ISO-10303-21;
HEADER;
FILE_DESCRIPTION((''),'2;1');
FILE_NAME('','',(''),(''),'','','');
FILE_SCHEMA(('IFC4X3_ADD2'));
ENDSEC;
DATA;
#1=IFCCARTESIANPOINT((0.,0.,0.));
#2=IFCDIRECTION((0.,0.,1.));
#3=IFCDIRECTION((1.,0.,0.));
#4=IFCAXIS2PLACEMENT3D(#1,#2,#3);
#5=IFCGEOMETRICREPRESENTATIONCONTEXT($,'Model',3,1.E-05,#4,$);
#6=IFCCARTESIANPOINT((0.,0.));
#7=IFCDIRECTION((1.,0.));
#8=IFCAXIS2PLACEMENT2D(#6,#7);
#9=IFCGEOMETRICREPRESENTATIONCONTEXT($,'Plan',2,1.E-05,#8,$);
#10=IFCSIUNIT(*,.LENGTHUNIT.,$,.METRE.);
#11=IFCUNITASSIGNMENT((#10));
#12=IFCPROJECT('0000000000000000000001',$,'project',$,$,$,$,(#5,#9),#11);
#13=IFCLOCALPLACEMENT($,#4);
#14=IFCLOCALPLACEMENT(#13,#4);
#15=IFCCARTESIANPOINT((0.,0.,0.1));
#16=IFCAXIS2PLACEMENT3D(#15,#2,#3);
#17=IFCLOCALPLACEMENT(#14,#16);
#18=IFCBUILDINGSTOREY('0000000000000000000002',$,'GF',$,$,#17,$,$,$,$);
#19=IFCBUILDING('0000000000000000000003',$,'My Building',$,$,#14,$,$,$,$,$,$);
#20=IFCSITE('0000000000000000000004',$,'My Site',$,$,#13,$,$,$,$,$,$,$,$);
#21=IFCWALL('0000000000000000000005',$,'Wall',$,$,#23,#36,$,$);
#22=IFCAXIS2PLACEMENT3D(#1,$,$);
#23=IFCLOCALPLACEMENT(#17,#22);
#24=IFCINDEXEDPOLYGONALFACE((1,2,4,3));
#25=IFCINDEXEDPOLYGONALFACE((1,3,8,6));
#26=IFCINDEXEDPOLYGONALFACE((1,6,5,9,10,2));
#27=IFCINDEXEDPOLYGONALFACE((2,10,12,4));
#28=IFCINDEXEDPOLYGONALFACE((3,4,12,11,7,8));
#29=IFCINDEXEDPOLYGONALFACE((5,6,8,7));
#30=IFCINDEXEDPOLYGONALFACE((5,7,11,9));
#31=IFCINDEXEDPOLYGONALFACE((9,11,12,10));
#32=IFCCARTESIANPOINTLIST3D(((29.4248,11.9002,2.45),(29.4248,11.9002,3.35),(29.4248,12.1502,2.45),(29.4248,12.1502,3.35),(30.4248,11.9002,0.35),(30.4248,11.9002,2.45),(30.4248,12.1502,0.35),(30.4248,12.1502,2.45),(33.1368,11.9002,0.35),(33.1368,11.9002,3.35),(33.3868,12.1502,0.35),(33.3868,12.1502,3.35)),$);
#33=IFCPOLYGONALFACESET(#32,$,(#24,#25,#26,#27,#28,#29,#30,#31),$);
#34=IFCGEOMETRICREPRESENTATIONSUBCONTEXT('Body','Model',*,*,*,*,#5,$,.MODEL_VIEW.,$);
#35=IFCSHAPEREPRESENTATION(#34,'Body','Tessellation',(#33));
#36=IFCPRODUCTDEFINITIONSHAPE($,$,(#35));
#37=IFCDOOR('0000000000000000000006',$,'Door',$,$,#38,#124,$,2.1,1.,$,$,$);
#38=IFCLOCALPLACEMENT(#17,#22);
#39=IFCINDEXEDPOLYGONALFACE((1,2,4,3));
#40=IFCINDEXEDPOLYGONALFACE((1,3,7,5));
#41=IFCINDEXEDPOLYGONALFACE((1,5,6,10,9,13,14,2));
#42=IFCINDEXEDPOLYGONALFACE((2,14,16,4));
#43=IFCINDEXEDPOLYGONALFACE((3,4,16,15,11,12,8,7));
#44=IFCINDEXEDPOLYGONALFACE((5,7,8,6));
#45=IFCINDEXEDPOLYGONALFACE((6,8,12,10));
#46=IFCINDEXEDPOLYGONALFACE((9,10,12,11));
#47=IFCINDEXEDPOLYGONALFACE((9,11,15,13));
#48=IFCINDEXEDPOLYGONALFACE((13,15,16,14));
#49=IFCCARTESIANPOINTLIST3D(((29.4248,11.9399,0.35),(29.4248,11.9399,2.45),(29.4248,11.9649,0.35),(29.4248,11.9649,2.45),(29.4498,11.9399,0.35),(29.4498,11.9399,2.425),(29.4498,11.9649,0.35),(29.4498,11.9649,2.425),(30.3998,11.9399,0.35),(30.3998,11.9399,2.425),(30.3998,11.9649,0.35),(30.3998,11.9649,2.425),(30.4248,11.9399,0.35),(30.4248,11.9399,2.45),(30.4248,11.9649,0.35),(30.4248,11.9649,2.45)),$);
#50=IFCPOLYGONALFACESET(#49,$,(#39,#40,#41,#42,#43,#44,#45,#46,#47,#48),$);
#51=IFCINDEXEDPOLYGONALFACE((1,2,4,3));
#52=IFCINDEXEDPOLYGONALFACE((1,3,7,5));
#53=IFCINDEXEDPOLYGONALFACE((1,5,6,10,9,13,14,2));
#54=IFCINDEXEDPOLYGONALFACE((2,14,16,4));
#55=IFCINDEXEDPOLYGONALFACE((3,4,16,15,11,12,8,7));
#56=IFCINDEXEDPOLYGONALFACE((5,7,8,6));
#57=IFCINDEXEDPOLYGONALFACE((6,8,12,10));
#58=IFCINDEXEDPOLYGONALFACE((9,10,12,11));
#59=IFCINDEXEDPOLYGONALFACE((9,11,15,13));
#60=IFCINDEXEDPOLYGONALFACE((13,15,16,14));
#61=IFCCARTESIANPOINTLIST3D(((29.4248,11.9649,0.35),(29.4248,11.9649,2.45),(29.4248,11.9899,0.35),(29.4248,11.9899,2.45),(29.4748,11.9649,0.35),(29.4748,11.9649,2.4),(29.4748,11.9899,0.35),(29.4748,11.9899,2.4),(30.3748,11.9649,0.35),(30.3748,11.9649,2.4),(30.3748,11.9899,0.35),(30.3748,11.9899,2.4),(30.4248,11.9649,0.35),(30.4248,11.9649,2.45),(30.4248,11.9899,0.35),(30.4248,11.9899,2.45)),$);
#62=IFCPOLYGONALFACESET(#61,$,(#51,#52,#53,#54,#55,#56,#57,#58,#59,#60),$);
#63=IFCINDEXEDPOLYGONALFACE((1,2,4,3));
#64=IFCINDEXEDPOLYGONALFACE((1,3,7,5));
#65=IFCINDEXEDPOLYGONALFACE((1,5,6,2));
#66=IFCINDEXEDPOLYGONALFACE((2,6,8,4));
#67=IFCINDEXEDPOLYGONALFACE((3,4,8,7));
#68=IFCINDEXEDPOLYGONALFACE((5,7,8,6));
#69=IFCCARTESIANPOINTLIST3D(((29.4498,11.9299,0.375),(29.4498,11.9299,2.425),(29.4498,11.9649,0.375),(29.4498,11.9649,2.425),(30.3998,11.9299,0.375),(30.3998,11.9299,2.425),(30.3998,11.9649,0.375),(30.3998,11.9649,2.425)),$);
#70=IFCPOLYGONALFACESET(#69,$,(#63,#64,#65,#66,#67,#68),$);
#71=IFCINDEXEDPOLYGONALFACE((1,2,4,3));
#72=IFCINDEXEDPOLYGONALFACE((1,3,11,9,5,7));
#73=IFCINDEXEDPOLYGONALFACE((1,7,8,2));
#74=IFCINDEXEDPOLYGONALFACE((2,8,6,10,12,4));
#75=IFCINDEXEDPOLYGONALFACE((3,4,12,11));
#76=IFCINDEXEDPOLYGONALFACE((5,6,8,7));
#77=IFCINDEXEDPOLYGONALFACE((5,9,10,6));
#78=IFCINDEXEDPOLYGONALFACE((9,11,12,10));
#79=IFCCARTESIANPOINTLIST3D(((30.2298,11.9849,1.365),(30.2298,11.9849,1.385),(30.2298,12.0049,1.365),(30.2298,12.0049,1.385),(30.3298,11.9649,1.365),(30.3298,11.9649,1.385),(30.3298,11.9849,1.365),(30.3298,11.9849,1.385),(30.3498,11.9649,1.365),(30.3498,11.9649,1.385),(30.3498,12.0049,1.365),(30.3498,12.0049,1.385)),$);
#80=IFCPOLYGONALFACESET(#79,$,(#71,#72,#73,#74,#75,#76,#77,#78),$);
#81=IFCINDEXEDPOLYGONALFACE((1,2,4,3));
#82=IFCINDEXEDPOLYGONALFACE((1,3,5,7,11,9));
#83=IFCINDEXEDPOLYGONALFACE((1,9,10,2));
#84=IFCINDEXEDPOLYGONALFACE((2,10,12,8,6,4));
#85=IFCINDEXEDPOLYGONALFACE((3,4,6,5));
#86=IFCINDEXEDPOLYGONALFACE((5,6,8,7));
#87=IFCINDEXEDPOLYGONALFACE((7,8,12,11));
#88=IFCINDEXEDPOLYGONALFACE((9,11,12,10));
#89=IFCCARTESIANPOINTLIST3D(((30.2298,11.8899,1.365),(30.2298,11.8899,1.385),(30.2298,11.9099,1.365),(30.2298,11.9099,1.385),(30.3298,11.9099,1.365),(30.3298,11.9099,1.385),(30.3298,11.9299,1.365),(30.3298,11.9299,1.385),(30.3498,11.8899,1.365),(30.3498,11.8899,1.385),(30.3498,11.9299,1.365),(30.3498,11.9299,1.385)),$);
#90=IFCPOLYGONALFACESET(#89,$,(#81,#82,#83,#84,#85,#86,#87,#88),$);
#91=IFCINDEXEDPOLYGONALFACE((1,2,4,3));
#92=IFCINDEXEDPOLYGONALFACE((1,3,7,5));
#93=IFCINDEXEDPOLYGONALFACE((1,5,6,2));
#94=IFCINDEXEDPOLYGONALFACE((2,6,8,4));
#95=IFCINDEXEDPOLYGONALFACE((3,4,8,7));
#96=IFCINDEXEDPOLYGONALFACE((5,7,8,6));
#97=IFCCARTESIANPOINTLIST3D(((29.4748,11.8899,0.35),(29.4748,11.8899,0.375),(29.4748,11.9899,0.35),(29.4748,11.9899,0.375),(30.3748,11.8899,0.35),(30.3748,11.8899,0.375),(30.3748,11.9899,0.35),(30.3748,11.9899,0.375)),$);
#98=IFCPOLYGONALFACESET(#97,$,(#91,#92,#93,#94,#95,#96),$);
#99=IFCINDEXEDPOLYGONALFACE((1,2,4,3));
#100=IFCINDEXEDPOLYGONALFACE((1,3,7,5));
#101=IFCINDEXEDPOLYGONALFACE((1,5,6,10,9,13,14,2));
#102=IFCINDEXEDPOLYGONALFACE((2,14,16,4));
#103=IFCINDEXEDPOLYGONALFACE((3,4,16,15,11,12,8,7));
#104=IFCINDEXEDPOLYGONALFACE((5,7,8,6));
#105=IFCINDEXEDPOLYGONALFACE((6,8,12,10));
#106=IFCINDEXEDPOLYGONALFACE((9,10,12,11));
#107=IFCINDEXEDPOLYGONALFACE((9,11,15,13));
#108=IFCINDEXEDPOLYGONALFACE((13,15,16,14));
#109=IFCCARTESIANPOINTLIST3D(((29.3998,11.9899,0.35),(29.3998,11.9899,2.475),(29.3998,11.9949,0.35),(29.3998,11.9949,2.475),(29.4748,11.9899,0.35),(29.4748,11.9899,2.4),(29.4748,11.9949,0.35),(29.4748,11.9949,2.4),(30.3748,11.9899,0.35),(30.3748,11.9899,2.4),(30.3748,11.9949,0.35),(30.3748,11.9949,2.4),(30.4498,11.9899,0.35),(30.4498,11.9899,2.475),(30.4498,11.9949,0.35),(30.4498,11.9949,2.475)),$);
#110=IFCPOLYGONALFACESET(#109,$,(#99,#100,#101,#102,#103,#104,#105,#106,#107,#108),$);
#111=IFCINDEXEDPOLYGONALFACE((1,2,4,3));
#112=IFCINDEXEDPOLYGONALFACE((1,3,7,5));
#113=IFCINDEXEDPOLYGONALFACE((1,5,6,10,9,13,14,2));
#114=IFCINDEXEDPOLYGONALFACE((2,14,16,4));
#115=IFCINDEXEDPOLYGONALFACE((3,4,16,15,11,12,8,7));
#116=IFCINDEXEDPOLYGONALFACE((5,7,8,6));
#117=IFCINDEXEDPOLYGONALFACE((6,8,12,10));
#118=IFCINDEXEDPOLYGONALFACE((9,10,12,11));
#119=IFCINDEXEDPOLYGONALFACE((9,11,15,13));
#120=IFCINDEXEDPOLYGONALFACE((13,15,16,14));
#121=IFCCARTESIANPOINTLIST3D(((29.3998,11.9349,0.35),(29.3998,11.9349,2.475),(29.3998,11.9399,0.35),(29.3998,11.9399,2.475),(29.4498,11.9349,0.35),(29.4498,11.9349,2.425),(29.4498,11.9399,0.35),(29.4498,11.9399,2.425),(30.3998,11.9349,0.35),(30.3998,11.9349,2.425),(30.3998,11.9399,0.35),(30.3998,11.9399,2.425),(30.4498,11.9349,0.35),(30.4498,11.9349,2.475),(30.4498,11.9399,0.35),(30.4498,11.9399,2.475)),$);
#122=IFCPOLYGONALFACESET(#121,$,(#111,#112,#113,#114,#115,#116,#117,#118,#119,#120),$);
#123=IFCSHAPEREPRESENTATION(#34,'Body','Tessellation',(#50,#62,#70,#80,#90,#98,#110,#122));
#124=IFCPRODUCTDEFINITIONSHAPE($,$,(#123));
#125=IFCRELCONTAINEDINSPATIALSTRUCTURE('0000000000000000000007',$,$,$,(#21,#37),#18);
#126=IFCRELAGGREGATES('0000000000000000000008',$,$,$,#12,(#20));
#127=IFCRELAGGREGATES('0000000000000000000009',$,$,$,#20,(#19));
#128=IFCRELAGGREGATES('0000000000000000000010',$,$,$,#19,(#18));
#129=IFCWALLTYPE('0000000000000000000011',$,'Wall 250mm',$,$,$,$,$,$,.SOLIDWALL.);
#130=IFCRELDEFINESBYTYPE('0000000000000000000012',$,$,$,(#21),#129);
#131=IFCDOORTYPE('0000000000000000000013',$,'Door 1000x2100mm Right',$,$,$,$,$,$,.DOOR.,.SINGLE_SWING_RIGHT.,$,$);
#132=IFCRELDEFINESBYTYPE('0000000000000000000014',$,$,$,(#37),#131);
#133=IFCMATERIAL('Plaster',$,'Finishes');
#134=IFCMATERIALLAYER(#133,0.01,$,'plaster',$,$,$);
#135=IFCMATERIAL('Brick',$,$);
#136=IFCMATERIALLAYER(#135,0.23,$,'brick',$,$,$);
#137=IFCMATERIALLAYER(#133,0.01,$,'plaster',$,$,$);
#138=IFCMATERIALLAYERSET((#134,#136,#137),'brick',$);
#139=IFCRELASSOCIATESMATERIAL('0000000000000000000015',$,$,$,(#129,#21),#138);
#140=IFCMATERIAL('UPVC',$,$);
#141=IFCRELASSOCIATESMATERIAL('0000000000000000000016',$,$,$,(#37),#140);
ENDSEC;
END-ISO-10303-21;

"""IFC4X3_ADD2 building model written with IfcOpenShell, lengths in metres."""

from ifc_helpers import new_model, entity, si_unit, frame, origin_with_axes, origin_2d_with_axis, place, context, subcontext, project, spatial, line, indexed_curve, outline, extrude, shape, source, transform, mapped, material, layer, layer_set, layer_usage, type_object, type_shapes, element, fill, save


model = new_model("IFC4X3_ADD2")

# Units and contexts
model_context = context("Model", 3, precision=1e-05, world=origin_with_axes())
plan_context = context("Plan", 2, precision=1e-05, world=origin_2d_with_axis())
body_context_1 = subcontext(model_context, "Body", "Model", "MODEL_VIEW")
body_context_2 = subcontext(plan_context, "Body", "Plan", "PLAN_VIEW")
ifc_project = project(units=[si_unit("LENGTHUNIT", "METRE")], contexts=[model_context, plan_context])

# Site, building, storey
site_placement = place(None, origin_with_axes())
site = spatial("IfcSite", under=ifc_project, at=site_placement, Name="My Site")
building_placement = place(site_placement, origin_with_axes())
building = spatial("IfcBuilding", under=site, at=building_placement, Name="My Building")
storey_placement = place(building_placement, frame((0.0, 0.0, 0.1), z_axis=(0.0, 0.0, 1.0), x_axis=(1.0, 0.0, 0.0)))
storey = spatial("IfcBuildingStorey", under=building, at=storey_placement, Name="GF")

# Shared definitions
ifc_material_1 = material(Name="UPVC")

# Shared definitions
ifc_material_2 = material(Name="Plaster", Category="Finishes")
ifc_layer_1 = layer(ifc_material_2, 0.01, Name="plaster")
ifc_material_3 = material(Name="Brick")
ifc_layer_2 = layer(ifc_material_3, 0.23, Name="brick")
ifc_layer_3 = layer(ifc_material_2, 0.01, Name="plaster")
ifc_layer_set_1 = layer_set([ifc_layer_1, ifc_layer_2, ifc_layer_3], Name="brick")
wall_type_1 = type_object("IfcWallType", Name="Wall 250mm", PredefinedType="SOLIDWALL", material=ifc_layer_set_1)

# Wall, opening, door
ifc_layer_usage_1 = layer_usage(ifc_layer_set_1, "AXIS2", "POSITIVE", 0.0)
wall_1_placement = place(storey_placement, frame((33.3868, 12.1502, 0.35), z_axis=(0.0, 0.0, 1.0), x_axis=(-1.0, 0.0, 0.0)))
wall_1 = element("IfcWall", 1, at=wall_1_placement, inside=storey, type_object=wall_type_1, material=ifc_layer_usage_1, Name="Wall", context=body_context_1, shape_type="SweptSolid", body=[
    extrude(outline(indexed_curve([(0.0, 0.0), (0.25, 0.25), (3.962, 0.25), (3.962, 0.0)], segments=[line(1, 2, 3, 4, 1)])), origin_with_axes(), (0.0, 0.0, 1.0), 3.0),
])
shared_shape_1 = source(origin_with_axes(), body_context_1, "Body", "SweptSolid", [
    extrude(outline(indexed_curve([(0.0, 2.1), (1.0, 2.1), (1.0, -0.05), (0.0, -0.05), (0.0, 2.1)])), frame((0.0, -0.6, 0.0), z_axis=(0.0, -1.0, 0.0), x_axis=(1.0, 0.0, 0.0)), (0.0, 0.0, -1.0), 1.2),
])
opening_1_placement = place(wall_1_placement, frame((2.962, 0.1603, 0.0), z_axis=(0.0, 0.0, 1.0), x_axis=(1.0, 0.0, 0.0)))
opening_1 = element("IfcOpeningElement", 2, at=opening_1_placement, cuts=wall_1, PredefinedType="OPENING", context=body_context_1, shape_type="MappedRepresentation", body=[
    mapped(shared_shape_1, transform((0.0, 0.0, 0.0), x_axis=(1.0, 0.0, 0.0), y_axis=(0.0, 1.0, 0.0), z_axis=(0.0, 0.0, 1.0), scale=1.0)),
])
door_type_1 = type_object("IfcDoorType", Name="Door 1000x2100mm Right", OperationType="SINGLE_SWING_RIGHT", PredefinedType="DOOR")
shared_shape_2 = source(origin_with_axes(), body_context_1, "Body", "SweptSolid", [
    extrude(outline(indexed_curve([(0.0, 0.0), (0.0, 2.1), (1.0, 2.1), (1.0, 0.0), (0.975, 0.0), (0.975, 2.075), (0.025, 2.075), (0.025, 0.0)], segments=[line(1, 2, 3, 4, 5, 6, 7, 8, 1)])), frame((0.0, 0.025, 0.0), z_axis=(0.0, -1.0, 0.0), x_axis=(1.0, 0.0, 0.0)), (0.0, 0.0, -1.0), 0.025),
    extrude(outline(indexed_curve([(0.0, 0.0), (0.0, 2.1), (1.0, 2.1), (1.0, 0.0), (0.95, 0.0), (0.95, 2.05), (0.05, 2.05), (0.05, 0.0)], segments=[line(1, 2, 3, 4, 5, 6, 7, 8, 1)])), frame((0.0, 0.0, 0.0), z_axis=(0.0, -1.0, 0.0), x_axis=(1.0, 0.0, 0.0)), (0.0, 0.0, -1.0), 0.025),
    extrude(outline(indexed_curve([(0.0, 0.0), (0.95, 0.0), (0.95, 0.035), (0.0, 0.035)], segments=[line(1, 2, 3, 4, 1)])), frame((0.025, 0.025, 0.025), z_axis=(0.0, 0.0, 1.0), x_axis=(1.0, 0.0, 0.0)), (0.0, 0.0, 1.0), 2.05),
    extrude(outline(indexed_curve([(0.0, 0.0), (0.0, -0.04), (0.12, -0.04), (0.12, -0.02), (0.02, -0.02), (0.02, 0.0)], segments=[line(1, 2, 3, 4, 5, 6, 1)])), frame((0.075, 0.025, 1.015), z_axis=(0.0, 0.0, 1.0), x_axis=(1.0, 0.0, 0.0)), (0.0, 0.0, 1.0), 0.02),
    extrude(outline(indexed_curve([(0.0, 0.0), (0.0, 0.04), (0.12, 0.04), (0.12, 0.02), (0.02, 0.02), (0.02, 0.0)], segments=[line(1, 2, 3, 4, 5, 6, 1)])), frame((0.075, 0.06, 1.015), z_axis=(0.0, 0.0, 1.0), x_axis=(1.0, 0.0, 0.0)), (0.0, 0.0, 1.0), 0.02),
    extrude(outline(indexed_curve([(0.0, 0.0), (0.9, 0.0), (0.9, 0.1), (0.0, 0.1)], segments=[line(1, 2, 3, 4, 1)])), frame((0.05, 0.0, 0.0), z_axis=(0.0, 0.0, 1.0), x_axis=(1.0, 0.0, 0.0)), (0.0, 0.0, 1.0), 0.025),
    extrude(outline(indexed_curve([(0.0, 0.0), (0.0, 2.125), (1.05, 2.125), (1.05, 0.0), (0.975, 0.0), (0.975, 2.05), (0.075, 2.05), (0.075, 0.0)], segments=[line(1, 2, 3, 4, 5, 6, 7, 8, 1)])), frame((-0.025, -0.005, 0.0), z_axis=(0.0, -1.0, 0.0), x_axis=(1.0, 0.0, 0.0)), (0.0, 0.0, -1.0), 0.005),
    extrude(outline(indexed_curve([(0.0, 0.0), (0.0, 2.125), (1.05, 2.125), (1.05, 0.0), (1.0, 0.0), (1.0, 2.075), (0.05, 2.075), (0.05, 0.0)], segments=[line(1, 2, 3, 4, 5, 6, 7, 8, 1)])), frame((-0.025, 0.05, 0.0), z_axis=(0.0, -1.0, 0.0), x_axis=(1.0, 0.0, 0.0)), (0.0, 0.0, -1.0), 0.005),
])
shared_shape_3 = source(origin_with_axes(), body_context_2, "Body", "Curve2D", [
    entity("IfcIndexedPolyCurve", entity("IfcCartesianPointList2D", [[0.0, 0.0], [0.0, 0.05], [0.025, 0.05], [0.025, 0.025], [0.05, 0.025], [0.05, 0.0]]), [entity("IfcLineIndex", [1, 2, 3, 4, 5, 6, 1])]),
    entity("IfcIndexedPolyCurve", entity("IfcCartesianPointList2D", [[1.0, 0.0], [1.0, 0.05], [0.975, 0.05], [0.975, 0.025], [0.95, 0.025], [0.95, 0.0]]), [entity("IfcLineIndex", [1, 2, 3, 4, 5, 6, 1])]),
    entity("IfcTrimmedCurve", entity("IfcEllipse", entity("IfcAxis2Placement2D", entity("IfcCartesianPoint", [0.94, 0.05]), entity("IfcDirection", [1.0, 0.0])), 0.915, 0.95), [entity("IfcCartesianPoint", [0.94, 1.0])], [entity("IfcCartesianPoint", [0.025, 0.05])], True, "CARTESIAN"),
    entity("IfcIndexedPolyCurve", entity("IfcCartesianPointList2D", [[0.975, 0.05], [0.94, 0.05], [0.94, 1.0], [0.975, 1.0]]), [entity("IfcLineIndex", [1, 2, 3, 4, 1])]),
])
type_shapes(door_type_1, [shared_shape_2, shared_shape_3])
door_1_placement = place(opening_1_placement, origin_with_axes())
door_1 = element("IfcDoor", 3, at=door_1_placement, inside=storey, type_object=door_type_1, material=ifc_material_1, Name="Door", OverallHeight=2.1, OverallWidth=1.0, shapes=[
    shape(body_context_1, "Body", "MappedRepresentation", [mapped(shared_shape_2, transform((0.0, 0.0, 0.0), x_axis=(1.0, 0.0, 0.0), y_axis=(0.0, 1.0, 0.0), z_axis=(0.0, 0.0, 1.0), scale=1.0))]),
    shape(body_context_2, "Body", "MappedRepresentation", [mapped(shared_shape_3, transform((0.0, 0.0, 0.0), x_axis=(1.0, 0.0, 0.0), y_axis=(0.0, 1.0, 0.0), z_axis=(0.0, 0.0, 1.0), scale=1.0))]),
])
fill(opening_1, door_1)

save(model, "model.ifc")
